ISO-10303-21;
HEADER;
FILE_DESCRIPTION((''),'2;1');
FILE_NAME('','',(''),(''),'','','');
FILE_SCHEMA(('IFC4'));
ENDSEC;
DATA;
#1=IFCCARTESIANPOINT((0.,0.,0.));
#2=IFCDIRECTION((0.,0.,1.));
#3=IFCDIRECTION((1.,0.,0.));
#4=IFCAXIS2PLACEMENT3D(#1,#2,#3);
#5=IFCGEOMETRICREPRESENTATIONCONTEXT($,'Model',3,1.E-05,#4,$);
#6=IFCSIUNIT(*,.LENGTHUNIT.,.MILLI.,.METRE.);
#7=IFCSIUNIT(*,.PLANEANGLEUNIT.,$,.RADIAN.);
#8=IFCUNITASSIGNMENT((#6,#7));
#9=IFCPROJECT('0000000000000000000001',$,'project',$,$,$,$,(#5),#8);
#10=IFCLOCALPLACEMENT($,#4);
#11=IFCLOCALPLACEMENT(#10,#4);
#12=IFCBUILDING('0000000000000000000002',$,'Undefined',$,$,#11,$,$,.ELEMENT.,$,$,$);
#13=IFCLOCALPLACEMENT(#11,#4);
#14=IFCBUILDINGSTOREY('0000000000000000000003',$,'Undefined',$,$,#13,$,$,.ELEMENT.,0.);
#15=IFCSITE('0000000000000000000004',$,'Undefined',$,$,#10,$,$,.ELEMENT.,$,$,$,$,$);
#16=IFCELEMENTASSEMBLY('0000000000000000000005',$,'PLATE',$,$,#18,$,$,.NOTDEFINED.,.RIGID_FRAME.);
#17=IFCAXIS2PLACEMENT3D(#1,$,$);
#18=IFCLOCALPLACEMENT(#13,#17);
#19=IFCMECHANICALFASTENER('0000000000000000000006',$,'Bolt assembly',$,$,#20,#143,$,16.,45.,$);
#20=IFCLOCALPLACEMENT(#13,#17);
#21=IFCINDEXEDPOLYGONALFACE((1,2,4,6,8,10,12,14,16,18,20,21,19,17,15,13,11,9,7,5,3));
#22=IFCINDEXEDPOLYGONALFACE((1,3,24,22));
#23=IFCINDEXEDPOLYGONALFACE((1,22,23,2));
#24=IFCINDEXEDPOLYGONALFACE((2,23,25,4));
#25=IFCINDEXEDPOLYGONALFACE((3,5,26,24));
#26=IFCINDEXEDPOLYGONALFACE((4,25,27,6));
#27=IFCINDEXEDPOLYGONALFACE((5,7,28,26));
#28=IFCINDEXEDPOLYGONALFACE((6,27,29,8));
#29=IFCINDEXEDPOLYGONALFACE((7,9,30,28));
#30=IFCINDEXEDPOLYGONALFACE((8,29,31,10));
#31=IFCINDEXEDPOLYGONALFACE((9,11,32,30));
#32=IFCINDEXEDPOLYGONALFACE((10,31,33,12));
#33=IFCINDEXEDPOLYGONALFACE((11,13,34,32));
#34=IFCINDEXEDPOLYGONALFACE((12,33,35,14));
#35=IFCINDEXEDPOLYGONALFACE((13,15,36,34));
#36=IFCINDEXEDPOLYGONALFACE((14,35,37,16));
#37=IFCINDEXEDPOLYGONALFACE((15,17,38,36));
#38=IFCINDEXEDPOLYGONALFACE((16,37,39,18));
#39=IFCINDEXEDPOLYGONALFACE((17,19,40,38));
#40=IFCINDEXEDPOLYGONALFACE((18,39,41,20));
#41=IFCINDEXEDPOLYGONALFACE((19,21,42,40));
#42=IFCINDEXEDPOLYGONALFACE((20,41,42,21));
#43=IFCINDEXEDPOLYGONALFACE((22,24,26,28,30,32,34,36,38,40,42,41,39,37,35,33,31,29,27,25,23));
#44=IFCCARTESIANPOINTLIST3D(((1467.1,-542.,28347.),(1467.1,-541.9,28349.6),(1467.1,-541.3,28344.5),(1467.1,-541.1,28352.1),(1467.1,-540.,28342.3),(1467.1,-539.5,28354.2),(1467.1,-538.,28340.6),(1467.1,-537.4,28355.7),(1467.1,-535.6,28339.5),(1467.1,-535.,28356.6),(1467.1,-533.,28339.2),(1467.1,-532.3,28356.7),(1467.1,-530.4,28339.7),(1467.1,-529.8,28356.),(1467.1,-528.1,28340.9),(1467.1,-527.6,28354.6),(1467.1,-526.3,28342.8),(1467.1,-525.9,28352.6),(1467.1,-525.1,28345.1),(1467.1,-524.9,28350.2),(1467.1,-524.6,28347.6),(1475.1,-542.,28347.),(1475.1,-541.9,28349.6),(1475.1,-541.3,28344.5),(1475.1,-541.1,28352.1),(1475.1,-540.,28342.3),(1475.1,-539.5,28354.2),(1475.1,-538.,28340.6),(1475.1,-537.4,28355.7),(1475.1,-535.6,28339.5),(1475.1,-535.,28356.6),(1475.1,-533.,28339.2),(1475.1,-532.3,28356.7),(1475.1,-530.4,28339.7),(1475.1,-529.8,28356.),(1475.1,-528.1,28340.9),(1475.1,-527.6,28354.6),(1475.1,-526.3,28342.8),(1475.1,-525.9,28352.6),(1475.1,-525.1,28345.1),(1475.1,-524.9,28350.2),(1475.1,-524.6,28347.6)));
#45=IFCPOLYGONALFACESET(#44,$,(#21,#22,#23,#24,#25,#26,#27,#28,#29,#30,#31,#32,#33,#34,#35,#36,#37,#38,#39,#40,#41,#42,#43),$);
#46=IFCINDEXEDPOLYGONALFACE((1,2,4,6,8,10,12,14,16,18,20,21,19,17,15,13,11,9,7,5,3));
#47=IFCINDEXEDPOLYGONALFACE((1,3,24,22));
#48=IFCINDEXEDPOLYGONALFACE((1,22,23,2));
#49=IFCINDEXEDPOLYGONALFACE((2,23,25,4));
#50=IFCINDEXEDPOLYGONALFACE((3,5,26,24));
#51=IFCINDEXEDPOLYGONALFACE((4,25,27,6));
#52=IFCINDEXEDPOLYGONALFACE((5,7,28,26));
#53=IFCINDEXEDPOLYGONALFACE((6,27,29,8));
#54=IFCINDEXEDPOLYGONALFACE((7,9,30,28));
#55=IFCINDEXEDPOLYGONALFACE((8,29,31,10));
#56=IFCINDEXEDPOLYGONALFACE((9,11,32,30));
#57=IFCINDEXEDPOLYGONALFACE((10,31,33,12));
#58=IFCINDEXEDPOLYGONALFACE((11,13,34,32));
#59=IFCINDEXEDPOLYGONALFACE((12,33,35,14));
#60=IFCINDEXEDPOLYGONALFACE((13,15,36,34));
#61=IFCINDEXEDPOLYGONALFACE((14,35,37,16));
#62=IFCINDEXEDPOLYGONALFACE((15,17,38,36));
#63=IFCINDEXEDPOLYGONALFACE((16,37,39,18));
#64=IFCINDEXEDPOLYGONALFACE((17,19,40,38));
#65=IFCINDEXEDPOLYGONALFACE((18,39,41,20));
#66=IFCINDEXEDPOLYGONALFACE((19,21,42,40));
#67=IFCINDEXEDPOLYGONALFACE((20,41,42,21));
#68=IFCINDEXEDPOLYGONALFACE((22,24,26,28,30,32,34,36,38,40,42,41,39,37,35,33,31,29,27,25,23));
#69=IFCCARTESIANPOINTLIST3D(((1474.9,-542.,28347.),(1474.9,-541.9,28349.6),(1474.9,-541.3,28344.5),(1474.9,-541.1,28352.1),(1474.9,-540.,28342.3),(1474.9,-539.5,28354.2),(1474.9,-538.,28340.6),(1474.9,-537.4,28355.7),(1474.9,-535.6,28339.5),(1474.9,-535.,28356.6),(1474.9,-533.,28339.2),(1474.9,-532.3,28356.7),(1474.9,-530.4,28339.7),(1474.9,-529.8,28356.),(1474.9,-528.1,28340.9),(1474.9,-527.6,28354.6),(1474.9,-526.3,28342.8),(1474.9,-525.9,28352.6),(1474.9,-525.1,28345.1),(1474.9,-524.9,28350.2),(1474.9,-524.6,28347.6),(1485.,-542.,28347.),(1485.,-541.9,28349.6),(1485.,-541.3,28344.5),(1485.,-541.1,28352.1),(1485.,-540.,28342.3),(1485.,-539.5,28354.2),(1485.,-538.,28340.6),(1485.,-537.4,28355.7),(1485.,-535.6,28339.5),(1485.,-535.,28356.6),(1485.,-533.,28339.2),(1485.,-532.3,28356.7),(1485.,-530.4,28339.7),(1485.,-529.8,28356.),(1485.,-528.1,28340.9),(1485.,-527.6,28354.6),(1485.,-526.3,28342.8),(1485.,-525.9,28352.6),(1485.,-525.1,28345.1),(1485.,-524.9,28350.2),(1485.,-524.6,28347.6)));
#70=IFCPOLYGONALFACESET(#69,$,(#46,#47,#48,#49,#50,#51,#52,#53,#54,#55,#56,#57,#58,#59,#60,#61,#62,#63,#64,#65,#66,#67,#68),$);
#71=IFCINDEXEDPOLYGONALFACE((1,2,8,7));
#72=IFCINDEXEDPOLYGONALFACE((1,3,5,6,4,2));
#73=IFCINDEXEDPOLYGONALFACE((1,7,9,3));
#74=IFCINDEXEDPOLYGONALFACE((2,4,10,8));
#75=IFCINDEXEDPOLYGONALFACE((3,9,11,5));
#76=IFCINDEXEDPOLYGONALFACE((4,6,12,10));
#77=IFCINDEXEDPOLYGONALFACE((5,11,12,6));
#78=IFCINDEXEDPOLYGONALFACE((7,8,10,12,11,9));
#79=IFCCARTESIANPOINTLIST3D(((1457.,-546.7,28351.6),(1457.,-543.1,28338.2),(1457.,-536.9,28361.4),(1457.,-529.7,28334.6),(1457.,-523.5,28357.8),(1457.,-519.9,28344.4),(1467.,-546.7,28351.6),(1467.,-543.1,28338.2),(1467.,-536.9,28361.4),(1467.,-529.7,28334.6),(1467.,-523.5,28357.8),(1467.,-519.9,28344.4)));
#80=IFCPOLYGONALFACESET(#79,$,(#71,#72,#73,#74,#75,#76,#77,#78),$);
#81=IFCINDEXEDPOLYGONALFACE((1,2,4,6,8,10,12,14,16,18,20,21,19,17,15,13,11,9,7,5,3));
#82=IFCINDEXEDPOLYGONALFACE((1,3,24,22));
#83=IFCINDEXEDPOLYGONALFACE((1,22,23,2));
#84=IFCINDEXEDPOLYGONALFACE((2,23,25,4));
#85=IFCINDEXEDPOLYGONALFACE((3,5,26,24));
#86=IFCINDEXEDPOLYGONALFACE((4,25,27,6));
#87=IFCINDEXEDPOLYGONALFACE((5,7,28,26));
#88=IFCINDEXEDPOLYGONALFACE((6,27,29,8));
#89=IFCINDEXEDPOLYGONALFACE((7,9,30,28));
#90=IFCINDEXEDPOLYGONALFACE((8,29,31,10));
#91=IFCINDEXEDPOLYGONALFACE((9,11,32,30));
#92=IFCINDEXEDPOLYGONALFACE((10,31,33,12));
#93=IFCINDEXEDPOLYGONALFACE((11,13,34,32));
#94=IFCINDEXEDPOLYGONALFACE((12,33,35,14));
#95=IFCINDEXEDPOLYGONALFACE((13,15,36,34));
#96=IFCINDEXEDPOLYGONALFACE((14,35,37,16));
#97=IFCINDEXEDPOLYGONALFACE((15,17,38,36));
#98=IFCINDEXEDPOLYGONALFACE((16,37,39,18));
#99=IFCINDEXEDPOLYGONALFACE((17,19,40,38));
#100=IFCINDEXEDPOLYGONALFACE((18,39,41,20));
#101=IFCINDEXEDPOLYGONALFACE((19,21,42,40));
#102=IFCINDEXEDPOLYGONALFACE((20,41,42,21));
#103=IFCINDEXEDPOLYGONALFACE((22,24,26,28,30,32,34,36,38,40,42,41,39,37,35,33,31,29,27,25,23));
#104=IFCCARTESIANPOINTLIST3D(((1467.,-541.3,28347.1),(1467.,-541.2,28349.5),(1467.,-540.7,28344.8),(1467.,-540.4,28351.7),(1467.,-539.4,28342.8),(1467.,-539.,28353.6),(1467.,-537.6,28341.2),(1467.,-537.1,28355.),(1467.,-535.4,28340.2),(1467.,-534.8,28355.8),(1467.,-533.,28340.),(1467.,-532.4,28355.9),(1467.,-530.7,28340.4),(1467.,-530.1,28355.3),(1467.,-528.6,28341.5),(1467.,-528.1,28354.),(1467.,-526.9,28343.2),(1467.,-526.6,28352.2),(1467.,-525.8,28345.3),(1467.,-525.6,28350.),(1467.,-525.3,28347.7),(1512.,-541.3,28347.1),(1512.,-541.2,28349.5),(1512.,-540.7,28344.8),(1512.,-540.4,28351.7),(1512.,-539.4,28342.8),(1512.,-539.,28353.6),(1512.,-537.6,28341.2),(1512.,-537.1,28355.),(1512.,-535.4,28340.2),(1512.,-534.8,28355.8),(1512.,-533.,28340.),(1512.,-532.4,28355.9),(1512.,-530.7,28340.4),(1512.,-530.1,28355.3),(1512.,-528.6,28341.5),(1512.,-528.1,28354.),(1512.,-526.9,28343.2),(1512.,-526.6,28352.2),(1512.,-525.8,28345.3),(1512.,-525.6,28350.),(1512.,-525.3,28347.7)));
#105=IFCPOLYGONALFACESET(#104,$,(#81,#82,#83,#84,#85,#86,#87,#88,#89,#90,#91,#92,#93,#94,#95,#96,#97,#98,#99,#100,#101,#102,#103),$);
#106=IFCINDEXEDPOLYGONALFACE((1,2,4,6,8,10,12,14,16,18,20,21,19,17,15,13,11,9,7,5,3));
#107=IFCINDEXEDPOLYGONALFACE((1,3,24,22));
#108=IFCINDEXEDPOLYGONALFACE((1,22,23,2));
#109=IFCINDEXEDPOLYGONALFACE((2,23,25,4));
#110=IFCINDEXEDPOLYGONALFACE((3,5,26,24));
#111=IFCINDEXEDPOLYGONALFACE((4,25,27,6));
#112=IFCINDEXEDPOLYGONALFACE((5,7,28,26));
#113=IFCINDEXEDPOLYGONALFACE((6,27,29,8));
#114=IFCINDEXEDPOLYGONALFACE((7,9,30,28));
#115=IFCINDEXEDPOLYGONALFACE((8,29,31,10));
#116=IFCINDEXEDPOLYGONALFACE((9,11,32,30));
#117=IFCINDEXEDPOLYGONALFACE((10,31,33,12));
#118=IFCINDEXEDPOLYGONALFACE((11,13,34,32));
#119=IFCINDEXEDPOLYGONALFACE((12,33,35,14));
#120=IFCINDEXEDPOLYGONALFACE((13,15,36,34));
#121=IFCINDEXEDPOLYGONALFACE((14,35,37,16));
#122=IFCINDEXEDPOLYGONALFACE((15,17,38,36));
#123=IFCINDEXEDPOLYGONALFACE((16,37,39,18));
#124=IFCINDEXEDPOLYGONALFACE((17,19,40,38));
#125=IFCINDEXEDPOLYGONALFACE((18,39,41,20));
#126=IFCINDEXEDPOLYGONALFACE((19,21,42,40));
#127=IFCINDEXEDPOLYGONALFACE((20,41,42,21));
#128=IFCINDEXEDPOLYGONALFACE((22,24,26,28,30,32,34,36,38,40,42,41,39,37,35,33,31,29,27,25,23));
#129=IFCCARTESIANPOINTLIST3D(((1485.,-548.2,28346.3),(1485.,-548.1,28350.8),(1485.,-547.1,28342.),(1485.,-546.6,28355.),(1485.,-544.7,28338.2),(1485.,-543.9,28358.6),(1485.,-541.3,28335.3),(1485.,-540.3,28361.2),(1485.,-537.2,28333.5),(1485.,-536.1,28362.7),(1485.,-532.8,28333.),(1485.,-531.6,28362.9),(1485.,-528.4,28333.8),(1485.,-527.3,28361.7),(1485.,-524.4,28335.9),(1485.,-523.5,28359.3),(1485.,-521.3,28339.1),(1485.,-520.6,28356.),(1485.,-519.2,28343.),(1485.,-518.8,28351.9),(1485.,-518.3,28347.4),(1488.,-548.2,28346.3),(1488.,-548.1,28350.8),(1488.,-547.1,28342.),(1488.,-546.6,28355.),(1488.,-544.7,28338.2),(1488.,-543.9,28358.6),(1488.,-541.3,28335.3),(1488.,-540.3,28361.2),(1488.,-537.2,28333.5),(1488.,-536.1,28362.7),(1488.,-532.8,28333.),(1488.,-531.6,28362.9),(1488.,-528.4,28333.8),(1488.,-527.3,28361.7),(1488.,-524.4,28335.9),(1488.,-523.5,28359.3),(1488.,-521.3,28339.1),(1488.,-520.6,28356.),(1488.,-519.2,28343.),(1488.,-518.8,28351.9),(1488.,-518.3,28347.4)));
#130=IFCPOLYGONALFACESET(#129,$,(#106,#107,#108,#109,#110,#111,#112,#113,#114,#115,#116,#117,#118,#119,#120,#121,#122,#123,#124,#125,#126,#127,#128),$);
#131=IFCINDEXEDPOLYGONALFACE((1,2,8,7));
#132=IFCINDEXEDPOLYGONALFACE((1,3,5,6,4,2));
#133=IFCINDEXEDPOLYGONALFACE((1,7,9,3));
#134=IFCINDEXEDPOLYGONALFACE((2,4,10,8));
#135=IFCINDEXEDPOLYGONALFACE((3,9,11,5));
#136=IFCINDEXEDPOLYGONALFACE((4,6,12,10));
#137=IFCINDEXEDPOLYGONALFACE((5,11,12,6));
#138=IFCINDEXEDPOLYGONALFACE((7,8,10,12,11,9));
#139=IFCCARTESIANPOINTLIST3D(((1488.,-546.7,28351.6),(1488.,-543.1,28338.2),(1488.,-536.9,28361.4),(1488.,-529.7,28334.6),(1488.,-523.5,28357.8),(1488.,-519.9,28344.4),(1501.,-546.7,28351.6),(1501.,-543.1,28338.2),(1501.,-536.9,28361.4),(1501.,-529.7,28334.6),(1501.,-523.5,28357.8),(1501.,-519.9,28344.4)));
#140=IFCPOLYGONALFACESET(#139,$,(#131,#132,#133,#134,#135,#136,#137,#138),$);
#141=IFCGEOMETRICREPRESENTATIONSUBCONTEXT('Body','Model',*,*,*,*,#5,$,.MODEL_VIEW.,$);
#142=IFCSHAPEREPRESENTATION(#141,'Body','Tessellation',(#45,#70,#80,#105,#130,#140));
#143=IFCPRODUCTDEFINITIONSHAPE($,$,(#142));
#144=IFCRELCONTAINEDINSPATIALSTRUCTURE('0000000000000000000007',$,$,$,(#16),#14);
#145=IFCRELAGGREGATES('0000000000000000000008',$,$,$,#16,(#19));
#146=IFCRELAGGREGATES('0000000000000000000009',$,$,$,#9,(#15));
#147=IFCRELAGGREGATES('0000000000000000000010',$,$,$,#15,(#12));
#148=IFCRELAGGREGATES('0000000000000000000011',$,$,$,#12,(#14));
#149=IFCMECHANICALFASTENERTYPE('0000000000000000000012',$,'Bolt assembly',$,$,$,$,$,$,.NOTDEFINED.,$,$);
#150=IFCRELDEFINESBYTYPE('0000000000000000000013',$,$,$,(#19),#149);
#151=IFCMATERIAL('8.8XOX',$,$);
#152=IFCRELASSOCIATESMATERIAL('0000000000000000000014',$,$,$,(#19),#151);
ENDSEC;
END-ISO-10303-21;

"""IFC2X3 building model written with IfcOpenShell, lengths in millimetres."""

from ifc_helpers import new_model, si_unit, frame, origin_with_axes, origin_2d_with_axis, place, context, subcontext, project, spatial, polyline, circle, outline, extrude, source, transform, mapped, material, type_object, element, aggregate, save


model = new_model("IFC2X3")

# Units and contexts
model_context = context("Model", 3, precision=1e-05, world=origin_with_axes())
body_context = subcontext(model_context, "Body", "Model", "MODEL_VIEW")
ifc_project = project(units=[si_unit("LENGTHUNIT", "METRE", prefix="MILLI"), si_unit("PLANEANGLEUNIT", "RADIAN")], contexts=[model_context])

# Site, building, storey
site_placement = place(None, origin_with_axes())
site = spatial("IfcSite", under=ifc_project, at=site_placement, Name="Undefined", CompositionType="ELEMENT")
building_placement = place(site_placement, origin_with_axes())
building = spatial("IfcBuilding", under=site, at=building_placement, Name="Undefined", CompositionType="ELEMENT")
storey_placement = place(building_placement, origin_with_axes())
storey = spatial("IfcBuildingStorey", under=building, at=storey_placement, Name="Undefined", CompositionType="ELEMENT", Elevation=0.0)

# Shared definitions
ifc_material_1 = material(Name="8.8XOX")
mechanical_fastener_type = type_object("IfcMechanicalFastenerType", Name="Bolt assembly")
shared_shape = source(origin_with_axes(), body_context, "Body", "SweptSolid", [
    extrude(circle(Radius=8.8, at=origin_2d_with_axis()), frame((0.0, 7.1, 0.0), z_axis=(0.0, 1.0, 0.0), x_axis=(1.0, 0.0, 0.0)), (0.0, 0.0, 1.0), 8.0),
    extrude(circle(Radius=8.8, at=origin_2d_with_axis()), frame((0.0, 14.9, 0.0), z_axis=(0.0, 1.0, 0.0), x_axis=(1.0, 0.0, 0.0)), (0.0, 0.0, 1.0), 10.1),
    extrude(outline(polyline([(12.0, -6.9), (12.0, 6.9), (0.0, 13.9), (-12.0, 6.9), (-12.0, -6.9), (0.0, -13.9), (12.0, -6.9)])), frame((0.0, -3.0, 0.0), z_axis=(0.0, 1.0, 0.0), x_axis=(1.0, 0.0, 0.0)), (0.0, 0.0, 1.0), 10.0),
    extrude(circle(Radius=8.0, at=origin_2d_with_axis()), frame((0.0, 7.0, 0.0), z_axis=(0.0, 1.0, 0.0), x_axis=(1.0, 0.0, 0.0)), (0.0, 0.0, 1.0), 45.0),
    extrude(circle(Radius=15.0, at=origin_2d_with_axis()), frame((0.0, 25.0, 0.0), z_axis=(0.0, 1.0, 0.0), x_axis=(1.0, 0.0, 0.0)), (0.0, 0.0, 1.0), 3.0),
    extrude(outline(polyline([(12.0, -6.9), (12.0, 6.9), (0.0, 13.9), (-12.0, 6.9), (-12.0, -6.9), (0.0, -13.9), (12.0, -6.9)])), frame((0.0, 28.0, 0.0), z_axis=(0.0, 1.0, 0.0), x_axis=(1.0, 0.0, 0.0)), (0.0, 0.0, 1.0), 13.0),
])

# Element assembly, mechanical fastener
assembly_1_placement = place(storey_placement, origin_with_axes())
assembly_1 = element("IfcElementAssembly", 1, at=assembly_1_placement, inside=storey, Name="PLATE", AssemblyPlace="NOTDEFINED", PredefinedType="RIGID_FRAME")
mechanical_fastener_1_placement = place(assembly_1_placement, frame((1460.0, -533.3, 28348.0), z_axis=(0.0, 0.707107, 0.707107), x_axis=(0.0, -0.707107, 0.707107)))
mechanical_fastener_1 = element("IfcMechanicalFastener", 2, at=mechanical_fastener_1_placement, type_object=mechanical_fastener_type, material=ifc_material_1, Name="Bolt assembly", NominalDiameter=16.0, NominalLength=45.0, context=body_context, shape_type="MappedRepresentation", body=[
    mapped(shared_shape, transform((0.0, 0.0, 0.0))),
])
aggregate(assembly_1, [mechanical_fastener_1])

save(model, "model.ifc")
